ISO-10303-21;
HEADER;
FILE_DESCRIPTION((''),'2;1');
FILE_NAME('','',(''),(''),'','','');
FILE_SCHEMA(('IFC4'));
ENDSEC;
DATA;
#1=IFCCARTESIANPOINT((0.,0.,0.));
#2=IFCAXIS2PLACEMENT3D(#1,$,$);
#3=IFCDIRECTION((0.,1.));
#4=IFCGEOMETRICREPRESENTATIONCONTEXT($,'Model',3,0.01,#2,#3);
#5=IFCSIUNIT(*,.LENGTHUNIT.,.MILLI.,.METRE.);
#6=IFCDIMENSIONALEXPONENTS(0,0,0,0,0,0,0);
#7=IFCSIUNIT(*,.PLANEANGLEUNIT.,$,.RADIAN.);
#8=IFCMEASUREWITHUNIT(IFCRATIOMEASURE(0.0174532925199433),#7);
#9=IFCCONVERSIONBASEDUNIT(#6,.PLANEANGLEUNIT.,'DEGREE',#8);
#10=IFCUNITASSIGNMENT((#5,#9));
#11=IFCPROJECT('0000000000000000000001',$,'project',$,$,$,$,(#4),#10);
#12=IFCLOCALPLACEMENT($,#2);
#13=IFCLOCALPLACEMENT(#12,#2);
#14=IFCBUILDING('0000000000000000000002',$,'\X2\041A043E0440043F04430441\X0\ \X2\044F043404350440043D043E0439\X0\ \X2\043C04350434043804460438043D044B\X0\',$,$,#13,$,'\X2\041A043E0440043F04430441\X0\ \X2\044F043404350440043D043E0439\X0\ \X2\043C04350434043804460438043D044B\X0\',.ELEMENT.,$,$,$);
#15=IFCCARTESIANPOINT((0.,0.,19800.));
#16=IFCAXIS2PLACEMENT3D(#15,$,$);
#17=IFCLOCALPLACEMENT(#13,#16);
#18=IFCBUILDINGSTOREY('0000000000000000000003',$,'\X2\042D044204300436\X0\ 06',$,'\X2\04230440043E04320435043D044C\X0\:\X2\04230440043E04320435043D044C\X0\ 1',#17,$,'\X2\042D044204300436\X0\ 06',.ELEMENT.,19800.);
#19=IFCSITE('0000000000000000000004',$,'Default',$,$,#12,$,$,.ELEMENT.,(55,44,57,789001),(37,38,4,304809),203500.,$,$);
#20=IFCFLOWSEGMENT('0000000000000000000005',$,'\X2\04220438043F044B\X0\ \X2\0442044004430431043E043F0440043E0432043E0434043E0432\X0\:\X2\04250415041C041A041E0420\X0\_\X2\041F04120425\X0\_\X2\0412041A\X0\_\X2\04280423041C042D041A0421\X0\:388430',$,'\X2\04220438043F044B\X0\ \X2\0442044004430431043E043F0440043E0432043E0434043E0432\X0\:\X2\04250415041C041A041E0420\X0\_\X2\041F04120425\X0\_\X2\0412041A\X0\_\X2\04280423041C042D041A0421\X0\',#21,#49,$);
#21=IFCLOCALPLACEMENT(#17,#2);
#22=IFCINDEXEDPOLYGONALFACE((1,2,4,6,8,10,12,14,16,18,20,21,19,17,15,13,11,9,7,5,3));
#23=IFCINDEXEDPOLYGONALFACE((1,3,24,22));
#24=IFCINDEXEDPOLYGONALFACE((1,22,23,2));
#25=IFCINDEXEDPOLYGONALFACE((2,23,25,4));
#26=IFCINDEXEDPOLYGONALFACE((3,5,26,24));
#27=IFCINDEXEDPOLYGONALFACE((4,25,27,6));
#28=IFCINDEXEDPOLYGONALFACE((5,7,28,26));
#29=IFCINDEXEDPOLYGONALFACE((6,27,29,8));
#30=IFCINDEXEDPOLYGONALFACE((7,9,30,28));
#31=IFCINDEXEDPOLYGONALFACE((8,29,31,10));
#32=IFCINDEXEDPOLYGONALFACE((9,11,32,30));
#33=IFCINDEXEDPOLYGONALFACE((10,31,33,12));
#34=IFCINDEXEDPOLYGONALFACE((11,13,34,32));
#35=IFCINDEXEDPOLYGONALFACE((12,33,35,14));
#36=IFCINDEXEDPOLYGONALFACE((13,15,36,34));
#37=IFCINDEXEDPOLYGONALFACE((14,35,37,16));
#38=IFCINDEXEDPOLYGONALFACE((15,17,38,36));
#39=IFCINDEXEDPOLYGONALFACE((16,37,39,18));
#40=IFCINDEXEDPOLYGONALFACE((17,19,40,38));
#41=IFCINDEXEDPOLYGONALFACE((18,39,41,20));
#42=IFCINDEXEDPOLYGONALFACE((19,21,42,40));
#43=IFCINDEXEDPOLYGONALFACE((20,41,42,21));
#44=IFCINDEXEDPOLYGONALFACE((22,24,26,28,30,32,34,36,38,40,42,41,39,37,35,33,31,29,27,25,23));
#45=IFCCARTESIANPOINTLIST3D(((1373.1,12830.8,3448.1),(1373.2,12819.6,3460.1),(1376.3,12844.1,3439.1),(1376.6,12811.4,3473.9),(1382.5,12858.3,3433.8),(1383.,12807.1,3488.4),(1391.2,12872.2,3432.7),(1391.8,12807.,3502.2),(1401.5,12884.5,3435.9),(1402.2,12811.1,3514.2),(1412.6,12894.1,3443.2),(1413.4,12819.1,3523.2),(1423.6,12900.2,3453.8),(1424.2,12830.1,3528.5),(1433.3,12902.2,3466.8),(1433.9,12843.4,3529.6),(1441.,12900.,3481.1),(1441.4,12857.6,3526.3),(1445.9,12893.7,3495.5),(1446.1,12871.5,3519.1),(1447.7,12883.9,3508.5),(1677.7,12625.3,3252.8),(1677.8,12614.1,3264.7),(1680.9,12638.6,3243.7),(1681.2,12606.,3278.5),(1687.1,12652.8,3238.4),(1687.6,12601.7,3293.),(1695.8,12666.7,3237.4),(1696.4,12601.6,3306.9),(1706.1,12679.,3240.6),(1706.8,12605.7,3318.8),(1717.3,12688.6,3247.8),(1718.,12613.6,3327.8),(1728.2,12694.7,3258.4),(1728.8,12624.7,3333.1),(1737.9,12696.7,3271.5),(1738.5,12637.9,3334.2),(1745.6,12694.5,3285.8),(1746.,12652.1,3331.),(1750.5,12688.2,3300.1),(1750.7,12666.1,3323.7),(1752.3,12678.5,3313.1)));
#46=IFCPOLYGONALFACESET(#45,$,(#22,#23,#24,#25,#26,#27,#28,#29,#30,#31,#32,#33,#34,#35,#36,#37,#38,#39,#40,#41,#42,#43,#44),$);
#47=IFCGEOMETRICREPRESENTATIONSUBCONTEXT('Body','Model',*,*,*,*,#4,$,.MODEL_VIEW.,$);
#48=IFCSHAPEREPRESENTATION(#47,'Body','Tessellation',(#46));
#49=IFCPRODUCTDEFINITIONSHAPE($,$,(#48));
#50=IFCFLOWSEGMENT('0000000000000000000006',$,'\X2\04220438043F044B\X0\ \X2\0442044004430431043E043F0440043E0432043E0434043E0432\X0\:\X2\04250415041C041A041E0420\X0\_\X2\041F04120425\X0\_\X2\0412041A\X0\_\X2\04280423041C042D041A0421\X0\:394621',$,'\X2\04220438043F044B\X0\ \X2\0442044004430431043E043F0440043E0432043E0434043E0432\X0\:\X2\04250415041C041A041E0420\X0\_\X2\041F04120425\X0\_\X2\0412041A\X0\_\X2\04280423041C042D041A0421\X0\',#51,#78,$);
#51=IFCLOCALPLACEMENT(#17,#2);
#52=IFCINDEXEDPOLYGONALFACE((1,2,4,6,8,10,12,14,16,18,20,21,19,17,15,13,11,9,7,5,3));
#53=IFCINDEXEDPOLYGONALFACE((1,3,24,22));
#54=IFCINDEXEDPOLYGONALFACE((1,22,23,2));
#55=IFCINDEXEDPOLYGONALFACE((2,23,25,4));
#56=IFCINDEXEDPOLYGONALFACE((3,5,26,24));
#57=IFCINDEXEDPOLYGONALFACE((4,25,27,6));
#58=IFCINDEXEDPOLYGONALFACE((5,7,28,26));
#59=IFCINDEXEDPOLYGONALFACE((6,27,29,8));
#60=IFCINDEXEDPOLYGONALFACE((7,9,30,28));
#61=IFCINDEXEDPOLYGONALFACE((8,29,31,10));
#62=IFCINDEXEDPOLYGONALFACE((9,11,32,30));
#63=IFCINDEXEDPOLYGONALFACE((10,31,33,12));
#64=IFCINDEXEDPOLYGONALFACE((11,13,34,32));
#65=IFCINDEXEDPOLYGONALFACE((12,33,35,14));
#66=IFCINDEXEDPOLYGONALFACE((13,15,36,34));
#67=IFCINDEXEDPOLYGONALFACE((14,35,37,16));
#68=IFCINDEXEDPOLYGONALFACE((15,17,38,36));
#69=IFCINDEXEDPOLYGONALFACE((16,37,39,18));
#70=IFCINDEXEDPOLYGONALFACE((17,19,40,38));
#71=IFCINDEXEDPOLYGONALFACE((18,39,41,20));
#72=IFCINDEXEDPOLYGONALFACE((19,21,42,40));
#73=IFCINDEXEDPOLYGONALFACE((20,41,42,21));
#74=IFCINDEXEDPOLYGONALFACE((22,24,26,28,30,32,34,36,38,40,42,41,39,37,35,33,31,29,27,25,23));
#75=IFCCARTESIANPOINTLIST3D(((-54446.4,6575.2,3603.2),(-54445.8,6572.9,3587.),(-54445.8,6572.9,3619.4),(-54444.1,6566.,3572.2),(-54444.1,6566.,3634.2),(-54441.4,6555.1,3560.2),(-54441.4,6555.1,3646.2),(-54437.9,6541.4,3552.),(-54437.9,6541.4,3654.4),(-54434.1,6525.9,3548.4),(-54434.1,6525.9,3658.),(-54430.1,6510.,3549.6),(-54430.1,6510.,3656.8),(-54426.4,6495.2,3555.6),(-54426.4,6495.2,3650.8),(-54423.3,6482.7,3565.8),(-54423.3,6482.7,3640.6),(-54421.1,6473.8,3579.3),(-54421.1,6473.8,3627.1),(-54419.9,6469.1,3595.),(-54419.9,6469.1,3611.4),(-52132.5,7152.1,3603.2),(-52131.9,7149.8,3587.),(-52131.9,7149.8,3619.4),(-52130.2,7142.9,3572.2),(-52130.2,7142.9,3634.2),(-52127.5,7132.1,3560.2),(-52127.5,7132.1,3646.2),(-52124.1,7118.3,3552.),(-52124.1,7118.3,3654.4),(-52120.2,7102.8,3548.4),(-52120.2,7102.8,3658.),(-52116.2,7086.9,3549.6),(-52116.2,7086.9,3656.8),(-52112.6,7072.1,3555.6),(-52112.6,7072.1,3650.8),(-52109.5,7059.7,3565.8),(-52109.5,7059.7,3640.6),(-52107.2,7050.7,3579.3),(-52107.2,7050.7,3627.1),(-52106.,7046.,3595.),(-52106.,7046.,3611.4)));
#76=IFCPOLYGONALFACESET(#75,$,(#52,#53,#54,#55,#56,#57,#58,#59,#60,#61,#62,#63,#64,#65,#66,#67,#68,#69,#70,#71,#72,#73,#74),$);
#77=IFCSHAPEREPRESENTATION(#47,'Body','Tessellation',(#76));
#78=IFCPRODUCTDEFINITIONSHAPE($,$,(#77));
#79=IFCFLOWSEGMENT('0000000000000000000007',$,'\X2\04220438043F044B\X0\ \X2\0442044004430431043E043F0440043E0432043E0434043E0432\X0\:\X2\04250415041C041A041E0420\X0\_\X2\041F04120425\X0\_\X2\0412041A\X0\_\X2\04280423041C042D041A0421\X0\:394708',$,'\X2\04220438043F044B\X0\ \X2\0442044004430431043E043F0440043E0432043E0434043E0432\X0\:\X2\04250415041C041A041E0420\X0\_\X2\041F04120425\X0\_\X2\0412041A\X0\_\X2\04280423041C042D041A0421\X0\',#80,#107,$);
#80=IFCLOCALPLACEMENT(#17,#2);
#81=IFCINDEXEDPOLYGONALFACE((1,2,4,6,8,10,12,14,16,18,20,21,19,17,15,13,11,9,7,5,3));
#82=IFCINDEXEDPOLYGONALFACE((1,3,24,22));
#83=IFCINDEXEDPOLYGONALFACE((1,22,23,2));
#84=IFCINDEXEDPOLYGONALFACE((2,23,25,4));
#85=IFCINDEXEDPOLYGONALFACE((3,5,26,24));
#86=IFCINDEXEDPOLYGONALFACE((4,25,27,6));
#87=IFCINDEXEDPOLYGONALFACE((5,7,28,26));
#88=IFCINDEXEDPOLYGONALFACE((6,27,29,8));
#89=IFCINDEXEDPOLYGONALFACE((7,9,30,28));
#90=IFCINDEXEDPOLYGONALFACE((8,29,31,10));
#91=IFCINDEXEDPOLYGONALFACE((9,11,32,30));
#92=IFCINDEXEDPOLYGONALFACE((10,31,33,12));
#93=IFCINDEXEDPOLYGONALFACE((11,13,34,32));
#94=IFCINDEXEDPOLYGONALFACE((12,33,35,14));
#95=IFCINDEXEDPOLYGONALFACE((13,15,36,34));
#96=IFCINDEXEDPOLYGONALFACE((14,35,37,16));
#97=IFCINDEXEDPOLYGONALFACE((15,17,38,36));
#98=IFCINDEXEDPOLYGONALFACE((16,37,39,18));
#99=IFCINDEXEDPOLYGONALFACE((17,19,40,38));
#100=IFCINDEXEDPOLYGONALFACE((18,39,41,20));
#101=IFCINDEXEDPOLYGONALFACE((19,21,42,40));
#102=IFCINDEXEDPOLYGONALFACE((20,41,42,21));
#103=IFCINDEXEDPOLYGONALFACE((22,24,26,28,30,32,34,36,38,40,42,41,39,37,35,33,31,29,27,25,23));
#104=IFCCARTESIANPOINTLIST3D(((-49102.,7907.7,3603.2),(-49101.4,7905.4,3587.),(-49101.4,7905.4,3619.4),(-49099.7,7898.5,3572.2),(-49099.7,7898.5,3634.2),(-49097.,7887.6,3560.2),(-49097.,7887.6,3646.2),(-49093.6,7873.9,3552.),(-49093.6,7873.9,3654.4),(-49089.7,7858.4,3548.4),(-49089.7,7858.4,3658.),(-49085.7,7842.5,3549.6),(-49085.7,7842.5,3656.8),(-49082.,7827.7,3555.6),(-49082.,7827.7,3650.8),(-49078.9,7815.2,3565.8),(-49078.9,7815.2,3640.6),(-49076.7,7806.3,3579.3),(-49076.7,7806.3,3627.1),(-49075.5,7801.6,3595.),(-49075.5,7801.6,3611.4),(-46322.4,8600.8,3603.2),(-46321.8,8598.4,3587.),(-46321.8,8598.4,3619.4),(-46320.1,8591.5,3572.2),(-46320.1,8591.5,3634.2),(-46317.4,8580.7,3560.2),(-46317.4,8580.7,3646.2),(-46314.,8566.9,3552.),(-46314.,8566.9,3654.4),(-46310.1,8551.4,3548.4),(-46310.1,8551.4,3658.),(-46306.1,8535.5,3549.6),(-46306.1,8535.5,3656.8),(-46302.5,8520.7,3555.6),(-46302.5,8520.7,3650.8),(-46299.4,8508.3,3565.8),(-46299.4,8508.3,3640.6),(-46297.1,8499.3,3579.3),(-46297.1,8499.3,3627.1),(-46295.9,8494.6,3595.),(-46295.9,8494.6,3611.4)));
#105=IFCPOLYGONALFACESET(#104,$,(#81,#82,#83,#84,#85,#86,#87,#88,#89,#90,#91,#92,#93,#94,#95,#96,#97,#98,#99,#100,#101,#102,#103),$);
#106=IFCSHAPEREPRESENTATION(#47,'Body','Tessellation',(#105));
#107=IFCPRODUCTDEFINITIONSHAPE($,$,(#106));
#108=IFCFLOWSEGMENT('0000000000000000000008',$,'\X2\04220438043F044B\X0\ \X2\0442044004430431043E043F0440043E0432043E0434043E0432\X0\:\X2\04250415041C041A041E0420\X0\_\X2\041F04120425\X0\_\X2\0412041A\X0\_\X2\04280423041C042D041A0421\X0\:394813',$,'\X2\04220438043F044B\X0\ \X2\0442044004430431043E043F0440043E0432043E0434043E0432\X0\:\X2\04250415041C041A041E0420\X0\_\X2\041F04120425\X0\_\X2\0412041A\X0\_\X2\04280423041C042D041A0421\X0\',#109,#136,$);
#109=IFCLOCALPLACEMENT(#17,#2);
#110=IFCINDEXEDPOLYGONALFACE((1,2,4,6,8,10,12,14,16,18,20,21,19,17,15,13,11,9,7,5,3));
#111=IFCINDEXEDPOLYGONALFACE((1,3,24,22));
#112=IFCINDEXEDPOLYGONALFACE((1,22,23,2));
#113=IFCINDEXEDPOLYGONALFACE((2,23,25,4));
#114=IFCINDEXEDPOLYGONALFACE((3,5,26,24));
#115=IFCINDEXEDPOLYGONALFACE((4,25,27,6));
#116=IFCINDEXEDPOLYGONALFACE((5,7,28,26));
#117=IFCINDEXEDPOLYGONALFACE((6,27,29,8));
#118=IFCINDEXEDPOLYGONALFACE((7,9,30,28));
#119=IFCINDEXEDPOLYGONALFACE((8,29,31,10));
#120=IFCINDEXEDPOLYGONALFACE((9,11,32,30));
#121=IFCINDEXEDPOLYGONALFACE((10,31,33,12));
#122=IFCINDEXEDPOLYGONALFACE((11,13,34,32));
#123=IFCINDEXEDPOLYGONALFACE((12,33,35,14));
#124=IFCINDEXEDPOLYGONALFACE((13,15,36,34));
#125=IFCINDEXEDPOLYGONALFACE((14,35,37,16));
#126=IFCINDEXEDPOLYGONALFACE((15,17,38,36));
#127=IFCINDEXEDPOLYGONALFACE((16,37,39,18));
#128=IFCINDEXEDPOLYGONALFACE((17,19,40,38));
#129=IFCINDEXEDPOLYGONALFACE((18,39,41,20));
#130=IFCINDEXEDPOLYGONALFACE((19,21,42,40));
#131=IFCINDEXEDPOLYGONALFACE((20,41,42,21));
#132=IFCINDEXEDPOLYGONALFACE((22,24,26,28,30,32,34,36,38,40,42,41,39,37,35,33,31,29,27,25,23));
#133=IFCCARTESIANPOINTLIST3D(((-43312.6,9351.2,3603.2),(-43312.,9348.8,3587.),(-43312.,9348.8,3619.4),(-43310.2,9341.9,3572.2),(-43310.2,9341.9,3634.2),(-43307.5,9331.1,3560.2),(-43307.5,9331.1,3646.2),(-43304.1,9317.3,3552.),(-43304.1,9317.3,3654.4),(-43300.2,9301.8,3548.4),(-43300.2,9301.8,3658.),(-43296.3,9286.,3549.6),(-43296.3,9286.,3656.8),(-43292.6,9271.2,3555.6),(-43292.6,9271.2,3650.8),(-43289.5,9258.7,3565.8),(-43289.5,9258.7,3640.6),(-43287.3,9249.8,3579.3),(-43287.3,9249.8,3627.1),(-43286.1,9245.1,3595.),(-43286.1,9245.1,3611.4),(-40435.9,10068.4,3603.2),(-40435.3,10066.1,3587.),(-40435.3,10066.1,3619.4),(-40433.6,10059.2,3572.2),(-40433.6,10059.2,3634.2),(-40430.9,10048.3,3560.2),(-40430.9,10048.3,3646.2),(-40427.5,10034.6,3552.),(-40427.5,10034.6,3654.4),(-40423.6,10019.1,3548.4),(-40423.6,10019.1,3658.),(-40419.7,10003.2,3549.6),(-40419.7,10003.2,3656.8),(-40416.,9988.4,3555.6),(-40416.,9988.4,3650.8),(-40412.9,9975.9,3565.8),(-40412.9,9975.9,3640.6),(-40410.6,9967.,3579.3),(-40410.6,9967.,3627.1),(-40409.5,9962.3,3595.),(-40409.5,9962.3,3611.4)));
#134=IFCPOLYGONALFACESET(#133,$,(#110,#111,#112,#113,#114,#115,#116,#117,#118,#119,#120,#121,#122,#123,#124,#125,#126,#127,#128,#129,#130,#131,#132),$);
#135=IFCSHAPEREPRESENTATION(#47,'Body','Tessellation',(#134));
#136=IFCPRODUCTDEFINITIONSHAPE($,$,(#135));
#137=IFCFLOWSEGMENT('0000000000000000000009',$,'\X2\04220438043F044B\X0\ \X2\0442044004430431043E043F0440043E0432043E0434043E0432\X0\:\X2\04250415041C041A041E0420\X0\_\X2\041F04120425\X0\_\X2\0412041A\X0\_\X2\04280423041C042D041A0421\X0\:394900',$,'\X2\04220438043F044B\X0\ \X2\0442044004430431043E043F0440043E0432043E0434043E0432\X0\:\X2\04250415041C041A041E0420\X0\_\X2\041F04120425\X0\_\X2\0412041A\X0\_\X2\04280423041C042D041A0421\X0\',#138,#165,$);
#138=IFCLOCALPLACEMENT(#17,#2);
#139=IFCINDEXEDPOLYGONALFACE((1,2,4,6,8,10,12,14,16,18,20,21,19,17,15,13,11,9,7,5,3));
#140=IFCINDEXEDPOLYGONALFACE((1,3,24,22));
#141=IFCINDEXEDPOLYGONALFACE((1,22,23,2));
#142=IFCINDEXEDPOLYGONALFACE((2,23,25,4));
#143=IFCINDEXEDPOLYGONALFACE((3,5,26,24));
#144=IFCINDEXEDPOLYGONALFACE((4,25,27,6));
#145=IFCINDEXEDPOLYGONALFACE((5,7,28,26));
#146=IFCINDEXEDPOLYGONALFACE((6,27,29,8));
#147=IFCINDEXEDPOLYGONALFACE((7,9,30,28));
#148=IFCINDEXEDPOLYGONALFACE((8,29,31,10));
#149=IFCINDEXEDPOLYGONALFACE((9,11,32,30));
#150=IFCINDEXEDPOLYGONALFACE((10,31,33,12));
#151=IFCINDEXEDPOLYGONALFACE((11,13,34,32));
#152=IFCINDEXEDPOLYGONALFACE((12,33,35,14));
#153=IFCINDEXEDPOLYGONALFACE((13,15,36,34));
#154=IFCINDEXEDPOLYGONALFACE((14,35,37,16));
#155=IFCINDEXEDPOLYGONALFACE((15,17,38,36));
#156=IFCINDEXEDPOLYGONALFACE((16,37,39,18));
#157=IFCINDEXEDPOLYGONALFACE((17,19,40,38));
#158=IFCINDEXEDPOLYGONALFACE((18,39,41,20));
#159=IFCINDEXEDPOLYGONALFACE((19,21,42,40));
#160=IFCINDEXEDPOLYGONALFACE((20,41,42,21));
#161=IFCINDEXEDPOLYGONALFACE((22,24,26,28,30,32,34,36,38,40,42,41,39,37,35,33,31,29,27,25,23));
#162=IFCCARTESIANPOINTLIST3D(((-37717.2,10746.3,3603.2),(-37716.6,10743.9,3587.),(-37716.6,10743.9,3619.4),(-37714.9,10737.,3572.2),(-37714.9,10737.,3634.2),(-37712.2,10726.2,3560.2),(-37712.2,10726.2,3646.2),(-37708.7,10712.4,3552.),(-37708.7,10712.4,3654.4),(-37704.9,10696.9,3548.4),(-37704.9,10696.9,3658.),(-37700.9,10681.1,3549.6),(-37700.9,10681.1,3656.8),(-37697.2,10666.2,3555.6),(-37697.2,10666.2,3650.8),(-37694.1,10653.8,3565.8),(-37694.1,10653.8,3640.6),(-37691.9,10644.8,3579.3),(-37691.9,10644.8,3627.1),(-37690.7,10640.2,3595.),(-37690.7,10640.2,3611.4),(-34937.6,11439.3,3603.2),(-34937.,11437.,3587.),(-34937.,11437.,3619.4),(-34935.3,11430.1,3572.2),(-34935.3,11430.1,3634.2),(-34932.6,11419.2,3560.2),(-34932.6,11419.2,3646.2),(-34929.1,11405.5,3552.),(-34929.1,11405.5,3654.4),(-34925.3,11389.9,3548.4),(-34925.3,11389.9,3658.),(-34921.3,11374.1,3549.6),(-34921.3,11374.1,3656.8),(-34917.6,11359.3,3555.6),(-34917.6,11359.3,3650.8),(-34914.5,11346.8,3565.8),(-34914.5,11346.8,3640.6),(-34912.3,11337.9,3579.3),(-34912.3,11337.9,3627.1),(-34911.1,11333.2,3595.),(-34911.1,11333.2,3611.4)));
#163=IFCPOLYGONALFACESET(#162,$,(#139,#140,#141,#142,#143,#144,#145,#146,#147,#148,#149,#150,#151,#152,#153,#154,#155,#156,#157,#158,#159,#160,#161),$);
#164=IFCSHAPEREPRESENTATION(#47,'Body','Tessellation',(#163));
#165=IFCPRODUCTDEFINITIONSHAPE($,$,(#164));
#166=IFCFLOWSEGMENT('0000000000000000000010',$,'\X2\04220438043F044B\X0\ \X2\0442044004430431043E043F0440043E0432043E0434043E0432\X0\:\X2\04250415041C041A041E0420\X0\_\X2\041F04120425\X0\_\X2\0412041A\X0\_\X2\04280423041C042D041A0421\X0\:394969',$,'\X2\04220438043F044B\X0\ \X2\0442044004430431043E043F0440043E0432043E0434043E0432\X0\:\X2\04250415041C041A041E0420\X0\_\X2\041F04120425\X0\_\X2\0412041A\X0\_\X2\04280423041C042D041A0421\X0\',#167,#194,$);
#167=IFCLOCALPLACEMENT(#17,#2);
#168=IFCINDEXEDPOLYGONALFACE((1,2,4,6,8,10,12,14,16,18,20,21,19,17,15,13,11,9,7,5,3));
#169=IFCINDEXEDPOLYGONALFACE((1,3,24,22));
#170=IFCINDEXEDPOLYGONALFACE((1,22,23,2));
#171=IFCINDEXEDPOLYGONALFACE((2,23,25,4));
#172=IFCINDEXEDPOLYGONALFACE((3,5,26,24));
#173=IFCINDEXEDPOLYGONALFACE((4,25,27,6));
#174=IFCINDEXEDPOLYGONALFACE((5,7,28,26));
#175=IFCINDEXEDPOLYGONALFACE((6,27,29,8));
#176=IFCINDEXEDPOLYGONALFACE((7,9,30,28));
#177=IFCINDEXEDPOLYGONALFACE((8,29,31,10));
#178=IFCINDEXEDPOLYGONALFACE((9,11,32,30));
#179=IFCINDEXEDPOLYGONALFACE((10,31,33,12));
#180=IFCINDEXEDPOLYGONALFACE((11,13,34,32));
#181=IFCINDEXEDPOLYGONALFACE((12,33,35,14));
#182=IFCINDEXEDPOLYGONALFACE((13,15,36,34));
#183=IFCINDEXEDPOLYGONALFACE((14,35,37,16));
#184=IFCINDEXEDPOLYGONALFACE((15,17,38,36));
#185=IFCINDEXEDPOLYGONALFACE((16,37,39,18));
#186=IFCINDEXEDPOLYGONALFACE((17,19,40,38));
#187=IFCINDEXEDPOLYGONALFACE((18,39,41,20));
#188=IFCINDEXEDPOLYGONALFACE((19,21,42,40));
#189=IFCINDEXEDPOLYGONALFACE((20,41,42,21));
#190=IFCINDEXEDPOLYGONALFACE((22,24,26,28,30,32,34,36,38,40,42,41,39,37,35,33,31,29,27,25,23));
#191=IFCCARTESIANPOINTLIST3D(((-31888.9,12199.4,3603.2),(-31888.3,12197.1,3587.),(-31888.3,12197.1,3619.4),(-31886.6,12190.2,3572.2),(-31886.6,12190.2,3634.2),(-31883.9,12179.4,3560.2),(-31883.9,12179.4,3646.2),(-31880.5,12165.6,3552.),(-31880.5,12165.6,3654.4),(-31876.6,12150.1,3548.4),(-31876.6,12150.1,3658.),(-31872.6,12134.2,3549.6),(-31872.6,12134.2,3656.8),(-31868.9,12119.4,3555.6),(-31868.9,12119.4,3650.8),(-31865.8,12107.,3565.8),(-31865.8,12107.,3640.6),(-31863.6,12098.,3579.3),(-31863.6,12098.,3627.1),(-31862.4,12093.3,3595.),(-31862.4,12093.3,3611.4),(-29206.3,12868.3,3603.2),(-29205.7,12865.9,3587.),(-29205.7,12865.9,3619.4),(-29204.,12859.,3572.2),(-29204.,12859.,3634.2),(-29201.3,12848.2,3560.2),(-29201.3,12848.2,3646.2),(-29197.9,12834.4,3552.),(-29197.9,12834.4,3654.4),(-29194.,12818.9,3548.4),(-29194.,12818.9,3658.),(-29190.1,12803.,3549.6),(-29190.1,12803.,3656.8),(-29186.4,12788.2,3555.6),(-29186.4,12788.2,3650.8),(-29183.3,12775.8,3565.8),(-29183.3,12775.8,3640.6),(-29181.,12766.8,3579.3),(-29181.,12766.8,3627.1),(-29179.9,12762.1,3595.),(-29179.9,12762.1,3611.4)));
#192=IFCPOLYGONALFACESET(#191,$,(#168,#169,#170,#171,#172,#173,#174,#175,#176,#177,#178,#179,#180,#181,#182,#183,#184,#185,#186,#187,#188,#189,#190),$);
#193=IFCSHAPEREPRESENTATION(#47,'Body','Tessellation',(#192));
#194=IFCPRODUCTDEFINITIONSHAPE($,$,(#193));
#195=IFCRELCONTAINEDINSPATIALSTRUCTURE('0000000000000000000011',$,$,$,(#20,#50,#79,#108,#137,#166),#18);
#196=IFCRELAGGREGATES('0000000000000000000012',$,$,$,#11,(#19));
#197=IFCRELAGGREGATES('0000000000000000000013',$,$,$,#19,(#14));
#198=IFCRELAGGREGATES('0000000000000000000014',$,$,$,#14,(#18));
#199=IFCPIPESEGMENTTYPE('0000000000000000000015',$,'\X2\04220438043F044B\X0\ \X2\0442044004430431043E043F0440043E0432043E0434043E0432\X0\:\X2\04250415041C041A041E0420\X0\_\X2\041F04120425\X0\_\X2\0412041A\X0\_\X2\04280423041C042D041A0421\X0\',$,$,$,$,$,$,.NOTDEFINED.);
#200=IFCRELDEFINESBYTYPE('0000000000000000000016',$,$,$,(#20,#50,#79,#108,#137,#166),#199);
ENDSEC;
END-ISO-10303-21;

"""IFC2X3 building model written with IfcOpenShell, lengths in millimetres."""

from ifc_helpers import new_model, entity, si_unit, converted_unit, direction, frame, origin, origin_2d_with_axis, place, context, subcontext, project, spatial, circle, extrude, type_object, element, save


model = new_model("IFC2X3")

# Units and contexts
model_context = context("Model", 3, precision=0.01, world=origin(), true_north=direction((0.0, 1.0)))
body_context = subcontext(model_context, "Body", "Model", "MODEL_VIEW")
ifc_project = project(units=[si_unit("LENGTHUNIT", "METRE", prefix="MILLI"), converted_unit("PLANEANGLEUNIT", "DEGREE", entity("IfcRatioMeasure", 0.0174532925199433), si_unit("PLANEANGLEUNIT", "RADIAN"), dimensions=[0, 0, 0, 0, 0, 0, 0])], contexts=[model_context])

# Site, building, storey
site_placement = place(None, origin())
site = spatial("IfcSite", under=ifc_project, at=site_placement, Name="Default", CompositionType="ELEMENT", RefLatitude=(55, 44, 57, 789001), RefLongitude=(37, 38, 4, 304809), RefElevation=203500.0)
building_placement = place(site_placement, origin())
building = spatial("IfcBuilding", under=site, at=building_placement, Name="Корпус ядерной медицины", LongName="Корпус ядерной медицины", CompositionType="ELEMENT")
storey_placement = place(building_placement, frame((0.0, 0.0, 19800.0)))
storey = spatial("IfcBuildingStorey", under=building, at=storey_placement, Name="Этаж 06", ObjectType="Уровень:Уровень 1", LongName="Этаж 06", CompositionType="ELEMENT", Elevation=19800.0)

# Flow segments
pipe_segment_type = type_object("IfcPipeSegmentType", Name="Типы трубопроводов:ХЕМКОР_ПВХ_ВК_ШУМЭКС", PredefinedType="NOTDEFINED")
flow_segment_1_placement = place(storey_placement, frame((1371.3, 12599.5, 3235.6)))
element("IfcFlowSegment", 1, at=flow_segment_1_placement, inside=storey, type_object=pipe_segment_type, Name="Типы трубопроводов:ХЕМКОР_ПВХ_ВК_ШУМЭКС:388430", ObjectType="Типы трубопроводов:ХЕМКОР_ПВХ_ВК_ШУМЭКС", context=body_context, shape_type="SweptSolid", body=[
    extrude(circle(Radius=55.0, at=origin_2d_with_axis()), frame((38.9, 254.8, 245.5), z_axis=(0.731997, -0.493738, -0.469472), x_axis=(0.559193, 0.829038, 0.0)), (0.0, 0.0, 1.0), 416.1),
])
flow_segment_2_placement = place(storey_placement, frame((-54448.0, 6466.9, 3546.6)))
element("IfcFlowSegment", 2, at=flow_segment_2_placement, inside=storey, type_object=pipe_segment_type, Name="Типы трубопроводов:ХЕМКОР_ПВХ_ВК_ШУМЭКС:394621", ObjectType="Типы трубопроводов:ХЕМКОР_ПВХ_ВК_ШУМЭКС", context=body_context, shape_type="SweptSolid", body=[
    extrude(circle(Radius=55.0, at=origin_2d_with_axis()), frame((14.9, 55.0, 56.6), z_axis=(0.970296, 0.241922, 0.0), x_axis=(-0.241922, 0.970296, 0.0)), (0.0, 0.0, 1.0), 2384.7),
])
flow_segment_3_placement = place(storey_placement, frame((-49103.6, 7799.4, 3546.6)))
element("IfcFlowSegment", 3, at=flow_segment_3_placement, inside=storey, type_object=pipe_segment_type, Name="Типы трубопроводов:ХЕМКОР_ПВХ_ВК_ШУМЭКС:394708", ObjectType="Типы трубопроводов:ХЕМКОР_ПВХ_ВК_ШУМЭКС", context=body_context, shape_type="SweptSolid", body=[
    extrude(circle(Radius=55.0, at=origin_2d_with_axis()), frame((14.9, 55.0, 56.6), z_axis=(0.970296, 0.241922, 0.0), x_axis=(-0.241922, 0.970296, 0.0)), (0.0, 0.0, 1.0), 2864.7),
])
flow_segment_4_placement = place(storey_placement, frame((-43314.2, 9242.9, 3546.6)))
element("IfcFlowSegment", 4, at=flow_segment_4_placement, inside=storey, type_object=pipe_segment_type, Name="Типы трубопроводов:ХЕМКОР_ПВХ_ВК_ШУМЭКС:394813", ObjectType="Типы трубопроводов:ХЕМКОР_ПВХ_ВК_ШУМЭКС", context=body_context, shape_type="SweptSolid", body=[
    extrude(circle(Radius=55.0, at=origin_2d_with_axis()), frame((14.9, 55.0, 56.6), z_axis=(0.970296, 0.241922, 0.0), x_axis=(-0.241922, 0.970296, 0.0)), (0.0, 0.0, 1.0), 2964.7),
])
flow_segment_5_placement = place(storey_placement, frame((-37718.8, 10638.0, 3546.6)))
element("IfcFlowSegment", 5, at=flow_segment_5_placement, inside=storey, type_object=pipe_segment_type, Name="Типы трубопроводов:ХЕМКОР_ПВХ_ВК_ШУМЭКС:394900", ObjectType="Типы трубопроводов:ХЕМКОР_ПВХ_ВК_ШУМЭКС", context=body_context, shape_type="SweptSolid", body=[
    extrude(circle(Radius=55.0, at=origin_2d_with_axis()), frame((14.9, 55.0, 56.6), z_axis=(0.970296, 0.241922, 0.0), x_axis=(-0.241922, 0.970296, 0.0)), (0.0, 0.0, 1.0), 2864.7),
])
flow_segment_6_placement = place(storey_placement, frame((-31890.5, 12091.1, 3546.6)))
element("IfcFlowSegment", 6, at=flow_segment_6_placement, inside=storey, type_object=pipe_segment_type, Name="Типы трубопроводов:ХЕМКОР_ПВХ_ВК_ШУМЭКС:394969", ObjectType="Типы трубопроводов:ХЕМКОР_ПВХ_ВК_ШУМЭКС", context=body_context, shape_type="SweptSolid", body=[
    extrude(circle(Radius=55.0, at=origin_2d_with_axis()), frame((14.9, 55.0, 56.6), z_axis=(0.970296, 0.241922, 0.0), x_axis=(-0.241922, 0.970296, 0.0)), (0.0, 0.0, 1.0), 2764.7),
])

save(model, "model.ifc")
